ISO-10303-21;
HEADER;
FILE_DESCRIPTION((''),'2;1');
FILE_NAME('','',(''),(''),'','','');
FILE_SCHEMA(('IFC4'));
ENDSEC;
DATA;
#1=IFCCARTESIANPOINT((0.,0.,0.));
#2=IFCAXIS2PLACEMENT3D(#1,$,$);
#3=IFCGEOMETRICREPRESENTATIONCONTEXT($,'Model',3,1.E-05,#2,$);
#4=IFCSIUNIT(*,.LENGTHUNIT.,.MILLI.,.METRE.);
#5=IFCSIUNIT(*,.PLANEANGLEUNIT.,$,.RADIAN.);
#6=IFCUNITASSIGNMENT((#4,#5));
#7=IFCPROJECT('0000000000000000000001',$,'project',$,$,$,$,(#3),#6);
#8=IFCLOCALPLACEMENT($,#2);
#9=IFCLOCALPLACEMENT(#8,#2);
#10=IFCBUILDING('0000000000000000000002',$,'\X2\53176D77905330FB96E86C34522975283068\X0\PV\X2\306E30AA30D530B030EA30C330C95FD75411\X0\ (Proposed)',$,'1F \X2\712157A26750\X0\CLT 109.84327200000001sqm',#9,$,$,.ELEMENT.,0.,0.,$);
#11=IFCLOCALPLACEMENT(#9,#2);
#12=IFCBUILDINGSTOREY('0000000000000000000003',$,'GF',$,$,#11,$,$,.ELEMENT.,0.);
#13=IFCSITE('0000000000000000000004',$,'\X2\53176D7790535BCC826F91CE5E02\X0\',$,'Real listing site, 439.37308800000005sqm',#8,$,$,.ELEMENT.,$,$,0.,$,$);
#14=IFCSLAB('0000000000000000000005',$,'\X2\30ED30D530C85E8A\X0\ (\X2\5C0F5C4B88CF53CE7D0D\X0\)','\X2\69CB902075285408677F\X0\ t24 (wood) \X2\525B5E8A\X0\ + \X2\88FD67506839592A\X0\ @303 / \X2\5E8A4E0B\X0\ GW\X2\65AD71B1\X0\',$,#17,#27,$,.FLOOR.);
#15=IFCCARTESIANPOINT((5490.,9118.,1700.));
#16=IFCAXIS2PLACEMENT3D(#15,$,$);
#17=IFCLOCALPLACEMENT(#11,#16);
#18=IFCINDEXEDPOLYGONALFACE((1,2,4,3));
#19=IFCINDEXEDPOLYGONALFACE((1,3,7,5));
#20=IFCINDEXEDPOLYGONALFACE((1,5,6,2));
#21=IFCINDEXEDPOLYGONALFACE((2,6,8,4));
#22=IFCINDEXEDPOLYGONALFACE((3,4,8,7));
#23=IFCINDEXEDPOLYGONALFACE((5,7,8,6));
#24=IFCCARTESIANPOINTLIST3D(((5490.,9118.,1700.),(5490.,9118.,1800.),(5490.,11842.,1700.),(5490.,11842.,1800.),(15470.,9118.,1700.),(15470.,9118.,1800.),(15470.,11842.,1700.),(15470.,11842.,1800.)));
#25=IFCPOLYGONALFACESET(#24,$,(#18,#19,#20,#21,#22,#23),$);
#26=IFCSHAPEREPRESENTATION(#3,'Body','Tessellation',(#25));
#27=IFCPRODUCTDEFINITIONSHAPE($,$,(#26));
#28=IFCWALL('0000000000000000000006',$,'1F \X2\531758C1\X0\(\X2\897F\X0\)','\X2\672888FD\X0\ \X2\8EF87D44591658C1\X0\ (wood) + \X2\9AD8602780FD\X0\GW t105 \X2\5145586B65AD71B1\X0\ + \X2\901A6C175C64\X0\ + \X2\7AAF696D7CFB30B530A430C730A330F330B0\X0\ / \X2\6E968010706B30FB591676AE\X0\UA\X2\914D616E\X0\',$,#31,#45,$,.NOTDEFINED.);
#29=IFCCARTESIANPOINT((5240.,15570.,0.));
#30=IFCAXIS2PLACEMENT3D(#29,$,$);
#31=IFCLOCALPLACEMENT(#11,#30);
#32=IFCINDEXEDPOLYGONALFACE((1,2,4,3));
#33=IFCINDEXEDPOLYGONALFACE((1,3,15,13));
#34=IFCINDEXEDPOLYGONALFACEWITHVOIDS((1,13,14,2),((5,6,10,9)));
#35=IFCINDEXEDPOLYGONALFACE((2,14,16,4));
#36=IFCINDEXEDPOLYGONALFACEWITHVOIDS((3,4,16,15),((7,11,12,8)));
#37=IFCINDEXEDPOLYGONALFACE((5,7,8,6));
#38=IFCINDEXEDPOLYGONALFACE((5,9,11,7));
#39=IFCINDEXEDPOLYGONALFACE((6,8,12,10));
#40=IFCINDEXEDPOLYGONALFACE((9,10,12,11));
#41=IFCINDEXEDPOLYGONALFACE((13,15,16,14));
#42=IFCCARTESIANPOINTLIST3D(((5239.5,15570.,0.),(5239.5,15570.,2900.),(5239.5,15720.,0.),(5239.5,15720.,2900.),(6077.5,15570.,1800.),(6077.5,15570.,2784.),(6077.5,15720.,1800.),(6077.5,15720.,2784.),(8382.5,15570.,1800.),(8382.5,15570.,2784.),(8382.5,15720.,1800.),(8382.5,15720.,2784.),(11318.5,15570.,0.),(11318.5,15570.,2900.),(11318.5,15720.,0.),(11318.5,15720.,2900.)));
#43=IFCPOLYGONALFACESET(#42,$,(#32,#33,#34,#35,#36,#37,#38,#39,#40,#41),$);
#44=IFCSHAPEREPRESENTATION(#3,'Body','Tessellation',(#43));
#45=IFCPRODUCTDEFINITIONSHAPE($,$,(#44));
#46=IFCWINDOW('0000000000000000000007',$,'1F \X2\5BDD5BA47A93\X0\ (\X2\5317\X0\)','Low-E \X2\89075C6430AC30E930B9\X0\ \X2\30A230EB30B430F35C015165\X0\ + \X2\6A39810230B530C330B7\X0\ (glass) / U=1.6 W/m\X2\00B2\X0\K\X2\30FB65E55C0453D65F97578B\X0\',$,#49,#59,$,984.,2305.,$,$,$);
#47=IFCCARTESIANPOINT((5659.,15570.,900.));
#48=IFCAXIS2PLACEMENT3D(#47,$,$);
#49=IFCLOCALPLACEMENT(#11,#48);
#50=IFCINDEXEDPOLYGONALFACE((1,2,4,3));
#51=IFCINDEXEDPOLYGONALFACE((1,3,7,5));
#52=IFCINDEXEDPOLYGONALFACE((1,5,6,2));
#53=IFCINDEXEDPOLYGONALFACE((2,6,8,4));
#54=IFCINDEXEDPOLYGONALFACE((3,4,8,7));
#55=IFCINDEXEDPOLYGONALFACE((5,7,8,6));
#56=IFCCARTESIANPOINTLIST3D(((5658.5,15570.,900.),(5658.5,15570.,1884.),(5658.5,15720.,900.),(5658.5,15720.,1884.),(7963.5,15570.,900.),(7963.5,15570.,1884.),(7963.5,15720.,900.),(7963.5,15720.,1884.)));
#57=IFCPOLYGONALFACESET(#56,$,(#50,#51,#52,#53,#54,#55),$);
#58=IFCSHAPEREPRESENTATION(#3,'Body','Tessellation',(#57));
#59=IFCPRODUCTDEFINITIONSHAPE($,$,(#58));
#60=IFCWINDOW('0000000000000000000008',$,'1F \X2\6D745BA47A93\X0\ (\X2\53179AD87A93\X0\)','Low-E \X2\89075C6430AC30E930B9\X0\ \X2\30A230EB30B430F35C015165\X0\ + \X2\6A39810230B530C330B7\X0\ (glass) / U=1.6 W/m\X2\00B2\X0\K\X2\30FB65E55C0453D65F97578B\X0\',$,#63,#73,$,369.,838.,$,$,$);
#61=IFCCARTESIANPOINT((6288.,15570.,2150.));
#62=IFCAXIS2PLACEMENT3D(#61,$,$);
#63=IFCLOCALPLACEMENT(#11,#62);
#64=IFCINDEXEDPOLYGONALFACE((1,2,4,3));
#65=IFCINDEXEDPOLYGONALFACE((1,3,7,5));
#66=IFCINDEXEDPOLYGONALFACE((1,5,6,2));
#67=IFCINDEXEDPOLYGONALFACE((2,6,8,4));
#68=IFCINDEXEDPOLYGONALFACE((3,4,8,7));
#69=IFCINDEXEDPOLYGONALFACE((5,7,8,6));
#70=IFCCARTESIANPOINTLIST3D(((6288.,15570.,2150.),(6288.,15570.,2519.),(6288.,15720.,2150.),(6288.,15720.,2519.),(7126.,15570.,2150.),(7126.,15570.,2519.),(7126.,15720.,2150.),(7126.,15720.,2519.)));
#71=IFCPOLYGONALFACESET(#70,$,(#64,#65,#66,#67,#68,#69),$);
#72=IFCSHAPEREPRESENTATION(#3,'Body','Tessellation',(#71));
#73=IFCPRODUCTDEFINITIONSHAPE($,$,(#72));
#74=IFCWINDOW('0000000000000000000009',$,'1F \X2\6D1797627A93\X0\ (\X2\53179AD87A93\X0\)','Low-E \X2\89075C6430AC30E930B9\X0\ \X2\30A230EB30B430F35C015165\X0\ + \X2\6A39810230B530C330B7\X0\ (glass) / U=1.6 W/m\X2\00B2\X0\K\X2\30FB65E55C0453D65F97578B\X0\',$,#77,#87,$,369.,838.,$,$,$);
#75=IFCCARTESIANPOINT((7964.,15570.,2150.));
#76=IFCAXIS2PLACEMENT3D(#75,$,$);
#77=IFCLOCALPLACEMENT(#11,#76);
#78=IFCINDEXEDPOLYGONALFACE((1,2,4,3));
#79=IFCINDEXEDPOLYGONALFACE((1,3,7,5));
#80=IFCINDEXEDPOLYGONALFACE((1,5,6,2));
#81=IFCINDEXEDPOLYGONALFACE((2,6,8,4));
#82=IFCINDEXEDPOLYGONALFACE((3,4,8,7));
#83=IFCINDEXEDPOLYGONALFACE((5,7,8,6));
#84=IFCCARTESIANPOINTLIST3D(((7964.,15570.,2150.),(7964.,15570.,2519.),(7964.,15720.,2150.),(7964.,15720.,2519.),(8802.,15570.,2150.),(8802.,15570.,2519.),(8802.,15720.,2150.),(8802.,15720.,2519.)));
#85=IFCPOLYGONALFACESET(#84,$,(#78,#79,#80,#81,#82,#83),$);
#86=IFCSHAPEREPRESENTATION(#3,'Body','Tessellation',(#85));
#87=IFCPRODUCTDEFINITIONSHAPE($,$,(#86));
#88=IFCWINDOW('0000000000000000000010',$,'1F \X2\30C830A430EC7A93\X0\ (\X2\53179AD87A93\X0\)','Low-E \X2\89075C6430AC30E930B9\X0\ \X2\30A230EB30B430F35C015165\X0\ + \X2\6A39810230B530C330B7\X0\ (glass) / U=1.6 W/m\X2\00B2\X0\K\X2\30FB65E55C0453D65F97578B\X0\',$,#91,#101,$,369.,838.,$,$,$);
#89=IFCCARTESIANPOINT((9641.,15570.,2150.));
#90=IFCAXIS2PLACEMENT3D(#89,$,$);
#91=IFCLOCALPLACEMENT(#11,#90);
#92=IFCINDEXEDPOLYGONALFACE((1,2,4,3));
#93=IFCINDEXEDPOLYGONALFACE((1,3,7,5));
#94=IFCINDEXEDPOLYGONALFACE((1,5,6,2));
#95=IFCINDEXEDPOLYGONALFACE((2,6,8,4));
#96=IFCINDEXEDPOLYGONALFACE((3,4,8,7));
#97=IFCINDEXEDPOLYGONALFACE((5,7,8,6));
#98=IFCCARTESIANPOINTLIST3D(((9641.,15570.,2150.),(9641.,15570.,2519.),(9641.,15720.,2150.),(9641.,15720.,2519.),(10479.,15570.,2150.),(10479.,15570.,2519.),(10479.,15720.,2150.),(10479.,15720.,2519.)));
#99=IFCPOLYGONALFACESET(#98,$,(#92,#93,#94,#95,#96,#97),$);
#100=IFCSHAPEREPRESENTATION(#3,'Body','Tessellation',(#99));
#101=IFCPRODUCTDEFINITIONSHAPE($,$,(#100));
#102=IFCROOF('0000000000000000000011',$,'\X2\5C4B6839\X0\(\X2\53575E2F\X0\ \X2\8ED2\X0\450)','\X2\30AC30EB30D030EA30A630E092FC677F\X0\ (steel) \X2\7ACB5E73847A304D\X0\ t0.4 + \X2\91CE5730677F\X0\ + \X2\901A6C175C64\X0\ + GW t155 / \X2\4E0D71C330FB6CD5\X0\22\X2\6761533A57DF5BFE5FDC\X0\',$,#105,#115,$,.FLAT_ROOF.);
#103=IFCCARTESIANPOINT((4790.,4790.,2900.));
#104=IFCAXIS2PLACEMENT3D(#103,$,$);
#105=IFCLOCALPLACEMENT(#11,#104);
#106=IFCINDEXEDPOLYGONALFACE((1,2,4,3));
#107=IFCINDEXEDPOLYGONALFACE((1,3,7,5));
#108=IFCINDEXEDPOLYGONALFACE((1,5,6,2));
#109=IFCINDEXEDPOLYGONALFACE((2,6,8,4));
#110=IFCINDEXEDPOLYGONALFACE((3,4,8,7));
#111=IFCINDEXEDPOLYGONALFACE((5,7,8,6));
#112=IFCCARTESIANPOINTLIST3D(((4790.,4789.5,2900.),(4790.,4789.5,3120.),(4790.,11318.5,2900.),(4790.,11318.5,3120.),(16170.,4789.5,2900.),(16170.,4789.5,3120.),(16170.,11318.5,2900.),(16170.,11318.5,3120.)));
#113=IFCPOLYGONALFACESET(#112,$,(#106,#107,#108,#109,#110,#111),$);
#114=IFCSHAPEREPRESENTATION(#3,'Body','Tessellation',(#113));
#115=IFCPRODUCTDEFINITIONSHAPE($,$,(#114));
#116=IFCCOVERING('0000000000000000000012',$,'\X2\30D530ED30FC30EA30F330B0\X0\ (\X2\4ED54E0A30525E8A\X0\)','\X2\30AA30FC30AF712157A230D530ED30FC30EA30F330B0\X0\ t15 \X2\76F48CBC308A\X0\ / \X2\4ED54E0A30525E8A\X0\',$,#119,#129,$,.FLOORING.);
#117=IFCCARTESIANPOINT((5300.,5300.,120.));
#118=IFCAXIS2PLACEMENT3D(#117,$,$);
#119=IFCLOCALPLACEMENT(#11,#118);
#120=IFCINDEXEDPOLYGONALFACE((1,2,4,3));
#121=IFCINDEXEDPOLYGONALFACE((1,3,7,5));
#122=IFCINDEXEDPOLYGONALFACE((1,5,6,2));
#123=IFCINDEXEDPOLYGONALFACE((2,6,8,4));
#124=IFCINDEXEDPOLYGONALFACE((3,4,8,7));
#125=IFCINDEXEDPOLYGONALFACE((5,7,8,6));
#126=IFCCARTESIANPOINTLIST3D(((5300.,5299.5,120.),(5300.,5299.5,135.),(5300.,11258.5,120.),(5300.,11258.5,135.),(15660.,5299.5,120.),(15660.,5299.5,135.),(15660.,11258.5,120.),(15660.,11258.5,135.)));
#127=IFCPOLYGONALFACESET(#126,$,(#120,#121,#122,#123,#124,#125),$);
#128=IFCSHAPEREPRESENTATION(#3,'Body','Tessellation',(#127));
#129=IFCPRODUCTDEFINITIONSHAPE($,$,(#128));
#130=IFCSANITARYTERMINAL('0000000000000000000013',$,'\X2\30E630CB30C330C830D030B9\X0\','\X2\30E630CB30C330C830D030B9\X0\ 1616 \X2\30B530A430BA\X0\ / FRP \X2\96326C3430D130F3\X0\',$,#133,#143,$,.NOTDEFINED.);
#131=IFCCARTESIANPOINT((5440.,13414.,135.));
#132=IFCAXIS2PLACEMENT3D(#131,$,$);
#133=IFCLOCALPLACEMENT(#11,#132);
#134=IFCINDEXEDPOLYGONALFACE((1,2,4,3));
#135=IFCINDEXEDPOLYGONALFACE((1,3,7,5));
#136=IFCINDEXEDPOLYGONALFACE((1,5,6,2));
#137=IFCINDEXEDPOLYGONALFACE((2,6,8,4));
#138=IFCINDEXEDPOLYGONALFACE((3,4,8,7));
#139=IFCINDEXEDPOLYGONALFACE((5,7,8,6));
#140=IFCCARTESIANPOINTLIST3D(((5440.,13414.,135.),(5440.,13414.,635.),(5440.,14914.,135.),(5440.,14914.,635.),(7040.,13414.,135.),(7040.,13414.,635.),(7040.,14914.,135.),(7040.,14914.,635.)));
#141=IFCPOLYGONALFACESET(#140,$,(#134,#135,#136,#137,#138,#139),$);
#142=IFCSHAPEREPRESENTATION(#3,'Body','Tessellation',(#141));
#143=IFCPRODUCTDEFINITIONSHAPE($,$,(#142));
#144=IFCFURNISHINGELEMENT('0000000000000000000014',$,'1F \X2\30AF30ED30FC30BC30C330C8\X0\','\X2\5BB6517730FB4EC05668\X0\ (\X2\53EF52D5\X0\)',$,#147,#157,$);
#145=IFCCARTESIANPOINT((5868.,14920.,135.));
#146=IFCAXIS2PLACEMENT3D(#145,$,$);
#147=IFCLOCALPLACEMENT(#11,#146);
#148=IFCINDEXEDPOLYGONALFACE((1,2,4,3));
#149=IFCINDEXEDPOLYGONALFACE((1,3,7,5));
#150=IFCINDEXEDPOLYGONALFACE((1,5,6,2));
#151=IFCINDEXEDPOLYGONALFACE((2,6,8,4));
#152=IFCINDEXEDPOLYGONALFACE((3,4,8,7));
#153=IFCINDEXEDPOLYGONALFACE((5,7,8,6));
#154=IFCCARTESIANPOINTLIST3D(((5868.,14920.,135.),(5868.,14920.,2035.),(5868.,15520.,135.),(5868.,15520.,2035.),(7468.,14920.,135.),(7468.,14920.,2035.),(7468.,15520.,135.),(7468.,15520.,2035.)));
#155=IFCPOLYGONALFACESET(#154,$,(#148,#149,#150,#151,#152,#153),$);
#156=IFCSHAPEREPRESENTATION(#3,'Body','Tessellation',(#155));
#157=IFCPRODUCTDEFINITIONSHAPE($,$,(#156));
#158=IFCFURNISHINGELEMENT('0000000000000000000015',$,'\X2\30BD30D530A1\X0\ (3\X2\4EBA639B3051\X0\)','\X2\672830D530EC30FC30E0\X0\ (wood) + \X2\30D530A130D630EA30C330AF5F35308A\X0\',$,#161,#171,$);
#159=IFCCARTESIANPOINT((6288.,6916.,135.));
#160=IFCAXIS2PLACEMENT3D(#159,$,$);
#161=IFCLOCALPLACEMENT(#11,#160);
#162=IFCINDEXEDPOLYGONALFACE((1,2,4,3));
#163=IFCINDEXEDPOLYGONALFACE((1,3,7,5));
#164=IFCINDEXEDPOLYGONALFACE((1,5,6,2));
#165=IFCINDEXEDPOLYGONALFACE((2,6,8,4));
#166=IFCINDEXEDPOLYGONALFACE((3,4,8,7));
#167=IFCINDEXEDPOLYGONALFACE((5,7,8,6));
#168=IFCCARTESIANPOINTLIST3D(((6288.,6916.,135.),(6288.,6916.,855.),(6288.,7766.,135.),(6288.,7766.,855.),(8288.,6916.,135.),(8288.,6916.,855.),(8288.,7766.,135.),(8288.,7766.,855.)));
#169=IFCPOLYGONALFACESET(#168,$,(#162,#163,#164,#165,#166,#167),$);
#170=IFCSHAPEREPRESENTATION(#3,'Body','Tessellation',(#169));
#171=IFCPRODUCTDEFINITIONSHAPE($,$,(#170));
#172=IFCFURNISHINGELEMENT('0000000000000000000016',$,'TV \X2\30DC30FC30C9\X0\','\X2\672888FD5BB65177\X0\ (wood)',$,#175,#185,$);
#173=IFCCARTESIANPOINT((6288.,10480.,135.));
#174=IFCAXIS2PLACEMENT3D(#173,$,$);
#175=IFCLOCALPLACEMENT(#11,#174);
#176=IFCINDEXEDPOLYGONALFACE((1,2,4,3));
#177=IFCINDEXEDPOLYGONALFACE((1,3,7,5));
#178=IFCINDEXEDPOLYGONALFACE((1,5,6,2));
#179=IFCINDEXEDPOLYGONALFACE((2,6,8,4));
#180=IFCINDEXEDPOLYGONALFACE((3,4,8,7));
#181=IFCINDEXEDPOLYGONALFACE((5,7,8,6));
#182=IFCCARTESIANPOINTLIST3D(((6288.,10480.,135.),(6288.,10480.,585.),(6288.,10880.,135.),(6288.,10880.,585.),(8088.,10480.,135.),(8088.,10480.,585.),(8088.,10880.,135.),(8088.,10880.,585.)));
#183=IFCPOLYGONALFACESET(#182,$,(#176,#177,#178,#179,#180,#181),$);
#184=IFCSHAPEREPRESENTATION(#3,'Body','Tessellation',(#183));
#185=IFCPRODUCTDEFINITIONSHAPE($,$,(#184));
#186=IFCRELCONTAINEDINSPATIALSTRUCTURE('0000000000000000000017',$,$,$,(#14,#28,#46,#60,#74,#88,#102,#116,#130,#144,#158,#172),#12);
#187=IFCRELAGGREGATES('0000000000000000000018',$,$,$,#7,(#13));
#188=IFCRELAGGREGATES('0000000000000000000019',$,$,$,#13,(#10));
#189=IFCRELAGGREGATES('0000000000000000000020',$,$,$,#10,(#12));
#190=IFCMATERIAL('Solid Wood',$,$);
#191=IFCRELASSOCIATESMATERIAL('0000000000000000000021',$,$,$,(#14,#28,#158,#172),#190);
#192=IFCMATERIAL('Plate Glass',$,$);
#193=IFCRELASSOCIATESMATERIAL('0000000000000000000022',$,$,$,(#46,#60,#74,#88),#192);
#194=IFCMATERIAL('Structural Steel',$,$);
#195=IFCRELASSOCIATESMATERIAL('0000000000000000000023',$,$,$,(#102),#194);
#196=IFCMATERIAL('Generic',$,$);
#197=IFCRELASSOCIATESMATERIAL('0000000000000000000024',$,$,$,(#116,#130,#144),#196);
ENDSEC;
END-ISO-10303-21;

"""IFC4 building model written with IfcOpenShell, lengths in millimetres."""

from ifc_helpers import new_model, si_unit, frame, frame_2d, origin, place, context, project, spatial, rectangle, extrude, material, element, fill, save


model = new_model("IFC4")

# Units and contexts
model_context = context("Model", 3, precision=1e-05, world=origin())
ifc_project = project(units=[si_unit("LENGTHUNIT", "METRE", prefix="MILLI"), si_unit("PLANEANGLEUNIT", "RADIAN")], contexts=[model_context])

# Site, building, storey
site_placement = place(None, origin())
site = spatial("IfcSite", under=ifc_project, at=site_placement, Name="北海道富良野市", ObjectType="Real listing site, 439.37308800000005sqm", CompositionType="ELEMENT", RefElevation=0.0)
building_placement = place(site_placement, origin())
building = spatial("IfcBuilding", under=site, at=building_placement, Name="北海道・雨水利用とPVのオフグリッド志向 (Proposed)", ObjectType="1F 無垢材CLT 109.84327200000001sqm", CompositionType="ELEMENT", ElevationOfRefHeight=0.0, ElevationOfTerrain=0.0)
storey_placement = place(building_placement, origin())
storey = spatial("IfcBuildingStorey", under=building, at=storey_placement, Name="GF", CompositionType="ELEMENT", Elevation=0.0)

# Slab
ifc_material_1 = material(Name="Solid Wood")
slab_1_placement = place(storey_placement, frame((5490.0, 9118.0, 1700.0)))
element("IfcSlab", 1, at=slab_1_placement, inside=storey, material=ifc_material_1, Name="ロフト床 (小屋裏収納)", Description="構造用合板 t24 (wood) 剛床 + 製材根太 @303 / 床下 GW断熱", PredefinedType="FLOOR", context=model_context, shape_type="SweptSolid", body=[
    extrude(rectangle(XDim=9980.0, YDim=2724.0, at=frame_2d((4990.0, 1362.0))), frame((5490.0, 9118.0, 1700.0)), (0.0, 0.0, 1.0), 100.0),
])

# Shared definitions
ifc_material_2 = material(Name="Plate Glass")

# Wall, openings, windows
wall_1_placement = place(storey_placement, frame((5240.0, 15570.0, 0.0)))
wall_1 = element("IfcWall", 2, at=wall_1_placement, inside=storey, material=ifc_material_1, Name="1F 北壁(西)", Description="木製 軸組外壁 (wood) + 高性能GW t105 充填断熱 + 通気層 + 窯業系サイディング / 準耐火・外皮UA配慮", PredefinedType="NOTDEFINED", context=model_context, shape_type="SweptSolid", body=[
    extrude(rectangle(XDim=6079.0, YDim=150.0, at=frame_2d((3039.0, 75.0))), frame((5240.0, 15570.0, 0.0)), (0.0, 0.0, 1.0), 2900.0),
])
opening_1_placement = place(storey_placement, frame((5659.0, 15570.0, 900.0)))
opening_1 = element("IfcOpeningElement", 3, at=opening_1_placement, cuts=wall_1, PredefinedType="NOTDEFINED", context=model_context, shape_type="SweptSolid", body=[
    extrude(rectangle(XDim=2305.0, YDim=150.0, at=frame_2d((1152.0, 75.0))), frame((5659.0, 15570.0, 900.0)), (0.0, 0.0, 1.0), 984.0),
])
opening_2_placement = place(storey_placement, frame((6288.0, 15570.0, 2150.0)))
opening_2 = element("IfcOpeningElement", 4, at=opening_2_placement, cuts=wall_1, PredefinedType="NOTDEFINED", context=model_context, shape_type="SweptSolid", body=[
    extrude(rectangle(XDim=838.0, YDim=150.0, at=frame_2d((419.0, 75.0))), frame((6288.0, 15570.0, 2150.0)), (0.0, 0.0, 1.0), 369.0),
])
opening_3_placement = place(storey_placement, frame((7964.0, 15570.0, 2150.0)))
opening_3 = element("IfcOpeningElement", 5, at=opening_3_placement, cuts=wall_1, PredefinedType="NOTDEFINED", context=model_context, shape_type="SweptSolid", body=[
    extrude(rectangle(XDim=838.0, YDim=150.0, at=frame_2d((419.0, 75.0))), frame((7964.0, 15570.0, 2150.0)), (0.0, 0.0, 1.0), 369.0),
])
opening_4_placement = place(storey_placement, frame((9641.0, 15570.0, 2150.0)))
opening_4 = element("IfcOpeningElement", 6, at=opening_4_placement, cuts=wall_1, PredefinedType="NOTDEFINED", context=model_context, shape_type="SweptSolid", body=[
    extrude(rectangle(XDim=838.0, YDim=150.0, at=frame_2d((419.0, 75.0))), frame((9641.0, 15570.0, 2150.0)), (0.0, 0.0, 1.0), 369.0),
])
window_1_placement = place(storey_placement, frame((5659.0, 15570.0, 900.0)))
window_1 = element("IfcWindow", 7, at=window_1_placement, inside=storey, material=ifc_material_2, Name="1F 寝室窓 (北)", Description="Low-E 複層ガラス アルゴン封入 + 樹脂サッシ (glass) / U=1.6 W/m²K・日射取得型", OverallHeight=984.0, OverallWidth=2305.0, context=model_context, shape_type="SweptSolid", body=[
    extrude(rectangle(XDim=2305.0, YDim=150.0, at=frame_2d((1152.0, 75.0))), frame((5659.0, 15570.0, 900.0)), (0.0, 0.0, 1.0), 984.0),
])
fill(opening_1, window_1)
window_2_placement = place(storey_placement, frame((6288.0, 15570.0, 2150.0)))
window_2 = element("IfcWindow", 8, at=window_2_placement, inside=storey, material=ifc_material_2, Name="1F 浴室窓 (北高窓)", Description="Low-E 複層ガラス アルゴン封入 + 樹脂サッシ (glass) / U=1.6 W/m²K・日射取得型", OverallHeight=369.0, OverallWidth=838.0, context=model_context, shape_type="SweptSolid", body=[
    extrude(rectangle(XDim=838.0, YDim=150.0, at=frame_2d((419.0, 75.0))), frame((6288.0, 15570.0, 2150.0)), (0.0, 0.0, 1.0), 369.0),
])
fill(opening_2, window_2)
window_3_placement = place(storey_placement, frame((7964.0, 15570.0, 2150.0)))
window_3 = element("IfcWindow", 9, at=window_3_placement, inside=storey, material=ifc_material_2, Name="1F 洗面窓 (北高窓)", Description="Low-E 複層ガラス アルゴン封入 + 樹脂サッシ (glass) / U=1.6 W/m²K・日射取得型", OverallHeight=369.0, OverallWidth=838.0, context=model_context, shape_type="SweptSolid", body=[
    extrude(rectangle(XDim=838.0, YDim=150.0, at=frame_2d((419.0, 75.0))), frame((7964.0, 15570.0, 2150.0)), (0.0, 0.0, 1.0), 369.0),
])
fill(opening_3, window_3)
window_4_placement = place(storey_placement, frame((9641.0, 15570.0, 2150.0)))
window_4 = element("IfcWindow", 10, at=window_4_placement, inside=storey, material=ifc_material_2, Name="1F トイレ窓 (北高窓)", Description="Low-E 複層ガラス アルゴン封入 + 樹脂サッシ (glass) / U=1.6 W/m²K・日射取得型", OverallHeight=369.0, OverallWidth=838.0, context=model_context, shape_type="SweptSolid", body=[
    extrude(rectangle(XDim=838.0, YDim=150.0, at=frame_2d((419.0, 75.0))), frame((9641.0, 15570.0, 2150.0)), (0.0, 0.0, 1.0), 369.0),
])
fill(opening_4, window_4)

# Roof
ifc_material_3 = material(Name="Structural Steel")
roof_1_placement = place(storey_placement, frame((4790.0, 4790.0, 2900.0)))
element("IfcRoof", 11, at=roof_1_placement, inside=storey, material=ifc_material_3, Name="屋根(南帯 軒450)", Description="ガルバリウム鋼板 (steel) 立平葺き t0.4 + 野地板 + 通気層 + GW t155 / 不燃・法22条区域対応", PredefinedType="FLAT_ROOF", context=model_context, shape_type="SweptSolid", body=[
    extrude(rectangle(XDim=11380.0, YDim=6529.0, at=frame_2d((5690.0, 3264.0))), frame((4790.0, 4790.0, 2900.0)), (0.0, 0.0, 1.0), 220.0),
])

# Covering
ifc_material_4 = material(Name="Generic")
covering_1_placement = place(storey_placement, frame((5300.0, 5300.0, 120.0)))
element("IfcCovering", 12, at=covering_1_placement, inside=storey, material=ifc_material_4, Name="フローリング (仕上げ床)", Description="オーク無垢フローリング t15 直貼り / 仕上げ床", PredefinedType="FLOORING", context=model_context, shape_type="SweptSolid", body=[
    extrude(rectangle(XDim=10360.0, YDim=5959.0, at=frame_2d((5180.0, 2979.0))), frame((5300.0, 5300.0, 120.0)), (0.0, 0.0, 1.0), 15.0),
])

# Sanitary terminal
sanitary_terminal_placement = place(storey_placement, frame((5440.0, 13414.0, 135.0)))
element("IfcSanitaryTerminal", 13, at=sanitary_terminal_placement, inside=storey, material=ifc_material_4, Name="ユニットバス", Description="ユニットバス 1616 サイズ / FRP 防水パン", PredefinedType="NOTDEFINED", context=model_context, shape_type="SweptSolid", body=[
    extrude(rectangle(XDim=1600.0, YDim=1500.0, at=frame_2d((800.0, 750.0))), frame((5440.0, 13414.0, 135.0)), (0.0, 0.0, 1.0), 500.0),
])

# Furnishing elements
furnishing_1_placement = place(storey_placement, frame((5868.0, 14920.0, 135.0)))
element("IfcFurnishingElement", 14, at=furnishing_1_placement, inside=storey, material=ifc_material_4, Name="1F クローゼット", Description="家具・什器 (可動)", context=model_context, shape_type="SweptSolid", body=[
    extrude(rectangle(XDim=1600.0, YDim=600.0, at=frame_2d((800.0, 300.0))), frame((5868.0, 14920.0, 135.0)), (0.0, 0.0, 1.0), 1900.0),
])
furnishing_2_placement = place(storey_placement, frame((6288.0, 6916.0, 135.0)))
element("IfcFurnishingElement", 15, at=furnishing_2_placement, inside=storey, material=ifc_material_1, Name="ソファ (3人掛け)", Description="木フレーム (wood) + ファブリック張り", context=model_context, shape_type="SweptSolid", body=[
    extrude(rectangle(XDim=2000.0, YDim=850.0, at=frame_2d((1000.0, 425.0))), frame((6288.0, 6916.0, 135.0)), (0.0, 0.0, 1.0), 720.0),
])
furnishing_3_placement = place(storey_placement, frame((6288.0, 10480.0, 135.0)))
element("IfcFurnishingElement", 16, at=furnishing_3_placement, inside=storey, material=ifc_material_1, Name="TV ボード", Description="木製家具 (wood)", context=model_context, shape_type="SweptSolid", body=[
    extrude(rectangle(XDim=1800.0, YDim=400.0, at=frame_2d((900.0, 200.0))), frame((6288.0, 10480.0, 135.0)), (0.0, 0.0, 1.0), 450.0),
])

save(model, "model.ifc")
